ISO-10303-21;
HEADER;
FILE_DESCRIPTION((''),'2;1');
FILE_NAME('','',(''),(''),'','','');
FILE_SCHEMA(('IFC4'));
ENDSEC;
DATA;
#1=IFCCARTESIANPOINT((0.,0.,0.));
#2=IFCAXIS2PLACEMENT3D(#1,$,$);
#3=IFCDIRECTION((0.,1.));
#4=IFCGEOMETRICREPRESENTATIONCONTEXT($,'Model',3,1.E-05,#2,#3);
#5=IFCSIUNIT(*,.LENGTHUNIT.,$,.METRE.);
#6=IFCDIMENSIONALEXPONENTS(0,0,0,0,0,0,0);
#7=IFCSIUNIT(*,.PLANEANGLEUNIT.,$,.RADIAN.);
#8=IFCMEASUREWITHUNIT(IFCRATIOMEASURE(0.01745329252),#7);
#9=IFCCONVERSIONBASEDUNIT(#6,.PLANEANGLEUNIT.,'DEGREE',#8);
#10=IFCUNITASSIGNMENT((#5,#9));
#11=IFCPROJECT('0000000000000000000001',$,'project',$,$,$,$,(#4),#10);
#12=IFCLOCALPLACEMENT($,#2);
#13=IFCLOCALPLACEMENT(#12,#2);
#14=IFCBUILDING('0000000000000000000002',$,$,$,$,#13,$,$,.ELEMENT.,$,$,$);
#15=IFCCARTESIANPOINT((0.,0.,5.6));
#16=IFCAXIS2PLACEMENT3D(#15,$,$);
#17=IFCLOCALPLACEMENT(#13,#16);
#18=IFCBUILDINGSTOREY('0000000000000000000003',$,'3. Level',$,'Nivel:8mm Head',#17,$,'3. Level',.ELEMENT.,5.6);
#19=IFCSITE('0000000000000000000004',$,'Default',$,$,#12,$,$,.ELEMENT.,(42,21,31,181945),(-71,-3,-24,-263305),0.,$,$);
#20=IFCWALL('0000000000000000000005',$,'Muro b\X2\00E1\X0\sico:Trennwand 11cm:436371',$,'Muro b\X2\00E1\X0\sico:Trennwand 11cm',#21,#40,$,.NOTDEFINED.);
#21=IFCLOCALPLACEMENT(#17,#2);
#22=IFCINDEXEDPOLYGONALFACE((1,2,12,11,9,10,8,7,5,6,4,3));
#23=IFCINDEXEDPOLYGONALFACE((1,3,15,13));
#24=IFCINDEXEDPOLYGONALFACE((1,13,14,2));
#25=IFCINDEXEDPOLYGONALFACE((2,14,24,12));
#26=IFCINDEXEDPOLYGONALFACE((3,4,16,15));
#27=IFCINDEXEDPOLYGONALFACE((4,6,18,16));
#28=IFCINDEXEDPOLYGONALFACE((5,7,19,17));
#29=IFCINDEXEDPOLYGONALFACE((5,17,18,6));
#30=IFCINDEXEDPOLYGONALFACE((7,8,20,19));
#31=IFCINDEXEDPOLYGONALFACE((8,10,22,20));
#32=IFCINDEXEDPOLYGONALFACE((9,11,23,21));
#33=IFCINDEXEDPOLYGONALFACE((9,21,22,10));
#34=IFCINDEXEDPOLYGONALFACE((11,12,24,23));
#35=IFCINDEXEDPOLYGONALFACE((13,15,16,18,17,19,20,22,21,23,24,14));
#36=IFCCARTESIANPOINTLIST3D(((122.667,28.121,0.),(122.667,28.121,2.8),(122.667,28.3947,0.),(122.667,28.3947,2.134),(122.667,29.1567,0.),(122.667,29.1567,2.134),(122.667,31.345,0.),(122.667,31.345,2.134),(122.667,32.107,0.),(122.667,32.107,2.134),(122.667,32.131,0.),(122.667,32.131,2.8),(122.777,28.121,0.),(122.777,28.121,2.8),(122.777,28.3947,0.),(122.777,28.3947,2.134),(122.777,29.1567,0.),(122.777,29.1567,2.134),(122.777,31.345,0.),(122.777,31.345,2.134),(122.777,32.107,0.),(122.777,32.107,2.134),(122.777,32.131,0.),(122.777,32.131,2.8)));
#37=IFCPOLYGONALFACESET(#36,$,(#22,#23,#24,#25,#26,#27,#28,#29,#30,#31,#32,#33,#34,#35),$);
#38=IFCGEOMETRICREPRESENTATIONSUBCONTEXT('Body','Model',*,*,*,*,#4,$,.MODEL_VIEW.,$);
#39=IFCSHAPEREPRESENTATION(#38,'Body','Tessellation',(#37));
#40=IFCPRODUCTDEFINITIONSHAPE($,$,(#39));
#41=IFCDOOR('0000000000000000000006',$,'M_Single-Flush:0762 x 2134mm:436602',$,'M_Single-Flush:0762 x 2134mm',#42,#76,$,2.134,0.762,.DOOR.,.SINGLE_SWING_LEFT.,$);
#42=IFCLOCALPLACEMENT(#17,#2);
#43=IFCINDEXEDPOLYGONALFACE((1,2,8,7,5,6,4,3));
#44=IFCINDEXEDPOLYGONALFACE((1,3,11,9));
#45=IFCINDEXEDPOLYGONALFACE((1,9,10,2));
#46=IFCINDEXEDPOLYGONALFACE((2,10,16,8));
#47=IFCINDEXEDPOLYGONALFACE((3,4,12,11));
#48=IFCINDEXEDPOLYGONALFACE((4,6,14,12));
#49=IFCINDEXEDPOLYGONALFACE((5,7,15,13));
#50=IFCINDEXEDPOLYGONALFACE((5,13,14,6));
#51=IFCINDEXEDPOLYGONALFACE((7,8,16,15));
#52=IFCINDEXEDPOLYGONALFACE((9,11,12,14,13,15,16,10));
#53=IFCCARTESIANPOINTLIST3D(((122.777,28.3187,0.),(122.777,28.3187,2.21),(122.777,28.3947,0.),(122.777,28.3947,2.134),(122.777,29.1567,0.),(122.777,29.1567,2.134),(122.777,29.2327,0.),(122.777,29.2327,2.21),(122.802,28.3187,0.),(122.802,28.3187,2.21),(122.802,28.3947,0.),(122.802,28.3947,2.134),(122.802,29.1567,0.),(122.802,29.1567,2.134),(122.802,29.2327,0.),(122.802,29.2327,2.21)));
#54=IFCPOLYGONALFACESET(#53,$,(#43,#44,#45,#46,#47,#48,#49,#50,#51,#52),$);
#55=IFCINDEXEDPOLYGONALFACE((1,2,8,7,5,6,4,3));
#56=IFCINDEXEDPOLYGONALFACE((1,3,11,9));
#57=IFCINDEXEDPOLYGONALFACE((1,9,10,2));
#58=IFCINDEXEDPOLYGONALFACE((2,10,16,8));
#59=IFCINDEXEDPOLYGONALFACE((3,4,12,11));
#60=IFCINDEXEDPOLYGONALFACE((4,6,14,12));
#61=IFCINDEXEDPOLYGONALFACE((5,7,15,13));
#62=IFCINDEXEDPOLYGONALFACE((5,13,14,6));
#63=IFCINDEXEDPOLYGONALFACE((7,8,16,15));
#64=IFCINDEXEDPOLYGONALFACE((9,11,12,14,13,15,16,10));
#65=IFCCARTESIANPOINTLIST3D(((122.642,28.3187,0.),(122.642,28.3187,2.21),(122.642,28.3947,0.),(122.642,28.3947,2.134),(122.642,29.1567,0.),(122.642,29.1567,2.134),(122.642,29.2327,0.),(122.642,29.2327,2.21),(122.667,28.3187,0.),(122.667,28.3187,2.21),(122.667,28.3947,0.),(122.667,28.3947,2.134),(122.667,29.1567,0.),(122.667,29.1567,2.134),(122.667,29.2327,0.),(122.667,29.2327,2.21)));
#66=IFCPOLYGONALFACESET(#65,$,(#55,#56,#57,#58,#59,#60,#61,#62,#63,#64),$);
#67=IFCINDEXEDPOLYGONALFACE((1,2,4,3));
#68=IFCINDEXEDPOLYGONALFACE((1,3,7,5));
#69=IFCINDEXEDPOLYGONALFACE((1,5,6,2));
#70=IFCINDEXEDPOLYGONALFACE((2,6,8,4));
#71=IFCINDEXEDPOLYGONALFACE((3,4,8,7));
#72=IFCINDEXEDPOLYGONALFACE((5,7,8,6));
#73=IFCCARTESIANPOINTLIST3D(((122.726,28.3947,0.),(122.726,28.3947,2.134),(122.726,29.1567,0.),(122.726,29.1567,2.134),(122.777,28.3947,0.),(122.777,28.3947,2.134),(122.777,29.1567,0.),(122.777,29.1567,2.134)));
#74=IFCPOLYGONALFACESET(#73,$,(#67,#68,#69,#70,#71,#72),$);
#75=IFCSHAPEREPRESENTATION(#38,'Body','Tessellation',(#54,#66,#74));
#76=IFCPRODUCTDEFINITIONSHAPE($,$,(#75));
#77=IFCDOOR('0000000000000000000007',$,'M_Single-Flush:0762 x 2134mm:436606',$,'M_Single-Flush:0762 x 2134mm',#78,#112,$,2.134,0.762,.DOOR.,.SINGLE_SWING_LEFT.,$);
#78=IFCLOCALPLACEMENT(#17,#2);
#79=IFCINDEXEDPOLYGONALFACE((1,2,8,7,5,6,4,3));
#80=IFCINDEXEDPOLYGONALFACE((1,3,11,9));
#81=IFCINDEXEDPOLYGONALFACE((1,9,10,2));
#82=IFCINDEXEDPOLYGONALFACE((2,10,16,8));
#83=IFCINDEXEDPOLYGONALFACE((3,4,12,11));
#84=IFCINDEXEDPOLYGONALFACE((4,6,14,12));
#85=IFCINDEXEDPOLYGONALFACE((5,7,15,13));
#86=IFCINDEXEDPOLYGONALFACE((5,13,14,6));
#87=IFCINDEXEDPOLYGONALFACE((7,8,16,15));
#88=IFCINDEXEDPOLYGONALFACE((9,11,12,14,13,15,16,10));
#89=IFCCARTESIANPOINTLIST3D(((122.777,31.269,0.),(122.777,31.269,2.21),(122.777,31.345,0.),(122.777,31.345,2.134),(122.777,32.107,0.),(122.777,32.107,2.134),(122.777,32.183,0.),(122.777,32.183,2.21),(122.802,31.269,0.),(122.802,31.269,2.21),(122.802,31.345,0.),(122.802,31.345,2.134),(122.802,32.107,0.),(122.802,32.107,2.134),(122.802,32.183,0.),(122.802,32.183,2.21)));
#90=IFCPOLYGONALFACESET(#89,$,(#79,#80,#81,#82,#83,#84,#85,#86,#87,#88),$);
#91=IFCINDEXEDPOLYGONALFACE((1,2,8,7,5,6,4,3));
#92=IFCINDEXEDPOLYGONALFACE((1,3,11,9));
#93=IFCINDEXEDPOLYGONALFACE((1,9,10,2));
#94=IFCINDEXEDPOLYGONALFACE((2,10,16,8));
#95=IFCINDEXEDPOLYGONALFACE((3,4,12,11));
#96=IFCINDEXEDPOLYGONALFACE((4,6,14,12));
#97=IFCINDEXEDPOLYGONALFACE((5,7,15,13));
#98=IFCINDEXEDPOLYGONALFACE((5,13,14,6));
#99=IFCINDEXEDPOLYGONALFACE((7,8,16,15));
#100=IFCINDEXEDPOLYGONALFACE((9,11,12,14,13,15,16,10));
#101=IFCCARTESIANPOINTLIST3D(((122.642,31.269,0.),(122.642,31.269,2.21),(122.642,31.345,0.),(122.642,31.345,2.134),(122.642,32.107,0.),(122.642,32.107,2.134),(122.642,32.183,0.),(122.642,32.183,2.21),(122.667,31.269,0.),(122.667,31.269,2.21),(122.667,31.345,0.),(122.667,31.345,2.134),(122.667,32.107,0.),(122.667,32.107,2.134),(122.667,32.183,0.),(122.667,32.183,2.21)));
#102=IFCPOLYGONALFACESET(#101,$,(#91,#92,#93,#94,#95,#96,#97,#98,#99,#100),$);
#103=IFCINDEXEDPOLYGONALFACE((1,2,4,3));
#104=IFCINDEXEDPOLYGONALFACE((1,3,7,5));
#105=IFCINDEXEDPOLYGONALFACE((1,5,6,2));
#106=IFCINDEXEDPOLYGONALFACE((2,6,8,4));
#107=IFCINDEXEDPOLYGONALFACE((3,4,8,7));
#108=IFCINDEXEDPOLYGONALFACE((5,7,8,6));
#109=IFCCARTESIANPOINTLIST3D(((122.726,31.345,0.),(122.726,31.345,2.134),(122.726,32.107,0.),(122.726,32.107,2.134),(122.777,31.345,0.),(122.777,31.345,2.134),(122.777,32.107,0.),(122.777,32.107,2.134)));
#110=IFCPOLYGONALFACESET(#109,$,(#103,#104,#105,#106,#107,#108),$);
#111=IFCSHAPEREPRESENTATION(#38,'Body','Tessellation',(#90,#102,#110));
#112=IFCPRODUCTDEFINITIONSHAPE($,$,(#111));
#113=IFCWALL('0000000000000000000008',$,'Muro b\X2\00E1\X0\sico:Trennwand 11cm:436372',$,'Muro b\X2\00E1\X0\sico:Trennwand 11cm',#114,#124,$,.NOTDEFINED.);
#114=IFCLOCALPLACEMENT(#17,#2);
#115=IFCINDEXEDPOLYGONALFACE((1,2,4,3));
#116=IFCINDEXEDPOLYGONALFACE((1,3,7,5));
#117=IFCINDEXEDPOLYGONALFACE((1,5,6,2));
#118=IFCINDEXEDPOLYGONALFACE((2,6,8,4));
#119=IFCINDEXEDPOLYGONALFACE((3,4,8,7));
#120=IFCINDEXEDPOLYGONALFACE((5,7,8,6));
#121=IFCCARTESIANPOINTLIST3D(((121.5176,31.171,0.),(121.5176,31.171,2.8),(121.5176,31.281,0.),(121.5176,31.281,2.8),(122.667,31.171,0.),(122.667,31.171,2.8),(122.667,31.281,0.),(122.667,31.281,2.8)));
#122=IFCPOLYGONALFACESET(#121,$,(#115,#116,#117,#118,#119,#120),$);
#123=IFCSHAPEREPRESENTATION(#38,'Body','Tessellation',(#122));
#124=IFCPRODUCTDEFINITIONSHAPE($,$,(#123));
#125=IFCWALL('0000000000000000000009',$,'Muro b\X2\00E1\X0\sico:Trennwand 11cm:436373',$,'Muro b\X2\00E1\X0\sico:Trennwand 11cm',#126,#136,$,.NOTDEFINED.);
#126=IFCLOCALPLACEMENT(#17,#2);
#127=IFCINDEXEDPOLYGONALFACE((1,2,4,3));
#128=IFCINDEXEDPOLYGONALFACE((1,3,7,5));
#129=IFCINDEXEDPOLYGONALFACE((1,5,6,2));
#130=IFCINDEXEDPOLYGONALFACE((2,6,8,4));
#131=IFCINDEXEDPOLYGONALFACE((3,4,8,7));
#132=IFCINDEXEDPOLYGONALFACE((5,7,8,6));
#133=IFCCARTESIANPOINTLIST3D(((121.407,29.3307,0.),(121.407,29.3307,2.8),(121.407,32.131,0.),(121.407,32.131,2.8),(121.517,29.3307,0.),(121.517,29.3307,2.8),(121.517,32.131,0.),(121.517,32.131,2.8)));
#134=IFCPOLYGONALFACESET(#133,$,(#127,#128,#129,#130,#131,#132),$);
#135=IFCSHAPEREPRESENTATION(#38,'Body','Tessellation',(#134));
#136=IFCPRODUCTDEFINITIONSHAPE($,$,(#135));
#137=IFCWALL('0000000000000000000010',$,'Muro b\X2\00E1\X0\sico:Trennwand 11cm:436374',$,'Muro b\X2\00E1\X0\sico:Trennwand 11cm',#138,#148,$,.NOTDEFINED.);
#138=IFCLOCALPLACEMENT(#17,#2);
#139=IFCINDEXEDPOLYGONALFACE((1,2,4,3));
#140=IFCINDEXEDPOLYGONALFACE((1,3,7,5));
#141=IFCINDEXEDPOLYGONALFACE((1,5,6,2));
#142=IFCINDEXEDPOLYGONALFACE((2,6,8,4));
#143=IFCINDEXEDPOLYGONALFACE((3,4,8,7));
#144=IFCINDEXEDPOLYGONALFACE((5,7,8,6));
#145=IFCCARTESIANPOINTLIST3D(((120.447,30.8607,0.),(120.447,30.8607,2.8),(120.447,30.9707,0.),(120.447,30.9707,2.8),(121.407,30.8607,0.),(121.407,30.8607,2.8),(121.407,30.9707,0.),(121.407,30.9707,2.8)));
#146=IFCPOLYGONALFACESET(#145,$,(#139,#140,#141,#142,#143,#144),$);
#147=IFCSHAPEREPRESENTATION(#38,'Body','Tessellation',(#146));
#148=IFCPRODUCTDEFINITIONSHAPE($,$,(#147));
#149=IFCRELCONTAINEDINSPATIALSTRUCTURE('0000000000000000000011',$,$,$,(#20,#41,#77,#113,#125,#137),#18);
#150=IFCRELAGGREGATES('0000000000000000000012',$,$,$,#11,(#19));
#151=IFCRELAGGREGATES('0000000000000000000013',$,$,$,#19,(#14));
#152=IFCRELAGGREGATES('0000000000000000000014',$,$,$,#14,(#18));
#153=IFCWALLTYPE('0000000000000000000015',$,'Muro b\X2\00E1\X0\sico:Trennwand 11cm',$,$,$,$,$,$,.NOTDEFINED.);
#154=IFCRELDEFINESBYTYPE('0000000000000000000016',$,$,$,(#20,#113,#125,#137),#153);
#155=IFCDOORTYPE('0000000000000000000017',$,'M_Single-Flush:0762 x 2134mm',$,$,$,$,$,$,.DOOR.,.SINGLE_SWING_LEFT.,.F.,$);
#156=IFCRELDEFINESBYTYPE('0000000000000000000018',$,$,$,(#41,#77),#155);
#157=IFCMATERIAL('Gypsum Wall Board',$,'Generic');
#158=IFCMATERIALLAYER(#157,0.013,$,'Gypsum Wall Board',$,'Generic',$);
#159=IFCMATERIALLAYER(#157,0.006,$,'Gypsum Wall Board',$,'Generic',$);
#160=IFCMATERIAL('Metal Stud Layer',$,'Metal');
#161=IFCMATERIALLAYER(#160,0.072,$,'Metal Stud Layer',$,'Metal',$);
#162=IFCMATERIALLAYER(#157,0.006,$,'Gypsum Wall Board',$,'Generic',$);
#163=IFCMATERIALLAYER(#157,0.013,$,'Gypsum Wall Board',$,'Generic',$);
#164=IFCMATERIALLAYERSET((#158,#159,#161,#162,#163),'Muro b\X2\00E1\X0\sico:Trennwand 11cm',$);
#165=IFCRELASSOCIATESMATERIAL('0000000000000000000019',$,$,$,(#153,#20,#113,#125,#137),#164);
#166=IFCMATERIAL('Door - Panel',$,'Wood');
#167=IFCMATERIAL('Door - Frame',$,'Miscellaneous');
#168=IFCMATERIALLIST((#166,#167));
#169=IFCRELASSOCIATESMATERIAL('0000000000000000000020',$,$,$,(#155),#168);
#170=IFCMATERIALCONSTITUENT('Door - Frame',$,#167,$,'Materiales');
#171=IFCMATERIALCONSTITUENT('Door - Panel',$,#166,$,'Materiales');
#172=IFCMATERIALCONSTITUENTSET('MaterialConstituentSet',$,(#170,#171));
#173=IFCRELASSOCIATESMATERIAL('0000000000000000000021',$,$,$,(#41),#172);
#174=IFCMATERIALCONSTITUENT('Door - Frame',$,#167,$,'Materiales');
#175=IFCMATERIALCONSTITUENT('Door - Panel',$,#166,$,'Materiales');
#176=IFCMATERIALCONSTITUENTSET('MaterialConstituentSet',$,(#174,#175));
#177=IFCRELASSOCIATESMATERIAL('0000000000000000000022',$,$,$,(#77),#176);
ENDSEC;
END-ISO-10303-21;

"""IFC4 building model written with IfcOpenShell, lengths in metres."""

from ifc_helpers import new_model, entity, si_unit, converted_unit, direction, frame, frame_2d, origin, origin_2d_with_axis, place, context, subcontext, project, spatial, polyline, rectangle, outline, extrude, source, transform, mapped, material, material_list, layer, layer_set, layer_usage, constituent, constituent_set, type_object, type_shapes, element, fill, save


model = new_model("IFC4")

# Units and contexts
model_context = context("Model", 3, precision=1e-05, world=origin(), true_north=direction((0.0, 1.0)))
body_context = subcontext(model_context, "Body", "Model", "MODEL_VIEW")
ifc_project = project(units=[si_unit("LENGTHUNIT", "METRE"), converted_unit("PLANEANGLEUNIT", "DEGREE", entity("IfcRatioMeasure", 0.01745329252), si_unit("PLANEANGLEUNIT", "RADIAN"), dimensions=[0, 0, 0, 0, 0, 0, 0])], contexts=[model_context])

# Site, building, storey
site_placement = place(None, origin())
site = spatial("IfcSite", under=ifc_project, at=site_placement, Name="Default", CompositionType="ELEMENT", RefLatitude=(42, 21, 31, 181945), RefLongitude=(-71, -3, -24, -263305), RefElevation=0.0)
building_placement = place(site_placement, origin())
building = spatial("IfcBuilding", under=site, at=building_placement, CompositionType="ELEMENT")
storey_placement = place(building_placement, frame((0.0, 0.0, 5.6)))
storey = spatial("IfcBuildingStorey", under=building, at=storey_placement, Name="3. Level", ObjectType="Nivel:8mm Head", LongName="3. Level", CompositionType="ELEMENT", Elevation=5.6)

# Shared definitions
ifc_material_1 = material(Name="Gypsum Wall Board", Category="Generic")
ifc_layer_1 = layer(ifc_material_1, 0.013, Name="Gypsum Wall Board", Category="Generic")
ifc_layer_2 = layer(ifc_material_1, 0.006, Name="Gypsum Wall Board", Category="Generic")
ifc_material_2 = material(Name="Metal Stud Layer", Category="Metal")
ifc_layer_3 = layer(ifc_material_2, 0.072, Name="Metal Stud Layer", Category="Metal")
ifc_layer_4 = layer(ifc_material_1, 0.006, Name="Gypsum Wall Board", Category="Generic")
ifc_layer_5 = layer(ifc_material_1, 0.013, Name="Gypsum Wall Board", Category="Generic")
ifc_layer_set_1 = layer_set([ifc_layer_1, ifc_layer_2, ifc_layer_3, ifc_layer_4, ifc_layer_5], Name="Muro básico:Trennwand 11cm")
wall_type_1 = type_object("IfcWallType", Name="Muro básico:Trennwand 11cm", PredefinedType="NOTDEFINED", material=ifc_layer_set_1)
ifc_material_3 = material(Name="Door - Frame", Category="Miscellaneous")

# Shared definitions
ifc_material_4 = material(Name="Door - Panel", Category="Wood")
ifc_material_list_1 = material_list([ifc_material_4, ifc_material_3])
door_type_1 = type_object("IfcDoorType", Name="M_Single-Flush:0762 x 2134mm", OperationType="SINGLE_SWING_LEFT", ParameterTakesPrecedence=False, PredefinedType="DOOR", material=ifc_material_list_1)
shared_shape_1 = source(origin(), body_context, "Body", "SweptSolid", [
    extrude(outline(polyline([(-0.457, -1.124), (0.457, -1.124), (0.457, 1.086), (0.381, 1.086), (0.381, -1.048), (-0.381, -1.048), (-0.381, 1.086), (-0.457, 1.086), (-0.457, -1.124)])), frame((0.381, 0.135, 1.086), z_axis=(0.0, -1.0, 0.0), x_axis=(-1.0, 0.0, 0.0)), (0.0, 0.0, 1.0), 0.025),
    extrude(outline(polyline([(-1.124, -0.457), (1.086, -0.457), (1.086, -0.381), (-1.048, -0.381), (-1.048, 0.381), (1.086, 0.381), (1.086, 0.457), (-1.124, 0.457), (-1.124, -0.457)])), frame((0.381, 0.0, 1.086), z_axis=(0.0, -1.0, 0.0), x_axis=(0.0, 0.0, -1.0)), (0.0, 0.0, 1.0), 0.025),
    extrude(rectangle(XDim=0.762, YDim=0.051, at=origin_2d_with_axis()), frame((0.381, 0.0845, 0.0)), (0.0, 0.0, 1.0), 2.134),
])
type_shapes(door_type_1, [shared_shape_1])

# Wall, openings, doors
ifc_layer_usage_1 = layer_usage(ifc_layer_set_1, "AXIS2", "NEGATIVE", 0.055)
wall_1_placement = place(storey_placement, frame((122.722, 28.121, 0.0), z_axis=(0.0, 0.0, 1.0), x_axis=(0.0, 1.0, 0.0)))
wall_1 = element("IfcWall", 1, at=wall_1_placement, inside=storey, type_object=wall_type_1, material=ifc_layer_usage_1, Name="Muro básico:Trennwand 11cm:436371", ObjectType="Muro básico:Trennwand 11cm", PredefinedType="NOTDEFINED", context=body_context, shape_type="SweptSolid", body=[
    extrude(rectangle(XDim=4.01, YDim=0.11, at=frame_2d((2.005, 0.0), x_axis=(-1.0, 0.0))), origin(), (0.0, 0.0, 1.0), 2.8),
])
opening_1_placement = place(wall_1_placement, frame((1.0357, 0.055, 0.0)))
opening_1 = element("IfcOpeningElement", 2, at=opening_1_placement, cuts=wall_1, ObjectType="Opening", PredefinedType="OPENING", context=body_context, shape_type="SweptSolid", body=[
    extrude(rectangle(XDim=0.762, YDim=2.134, at=frame_2d((1.067, 0.381), x_axis=(0.0, -1.0))), frame((0.0, 0.0, 0.0), z_axis=(0.0, -1.0, 0.0), x_axis=(0.0, 0.0, 1.0)), (0.0, 0.0, 1.0), 0.11),
])
opening_2_placement = place(wall_1_placement, frame((3.986, 0.055, 0.0)))
opening_2 = element("IfcOpeningElement", 3, at=opening_2_placement, cuts=wall_1, ObjectType="Opening", PredefinedType="OPENING", context=body_context, shape_type="SweptSolid", body=[
    extrude(rectangle(XDim=0.762, YDim=2.134, at=frame_2d((1.067, 0.381), x_axis=(0.0, -1.0))), frame((0.0, 0.0, 0.0), z_axis=(0.0, -1.0, 0.0), x_axis=(0.0, 0.0, 1.0)), (0.0, 0.0, 1.0), 0.11),
])
ifc_constituent_1 = constituent(ifc_material_3, Name="Door - Frame", Category="Materiales")
ifc_constituent_2 = constituent(ifc_material_4, Name="Door - Panel", Category="Materiales")
ifc_constituent_set_1 = constituent_set(constituents=[ifc_constituent_1, ifc_constituent_2], Name="MaterialConstituentSet")
door_1_placement = place(opening_1_placement, frame((0.0, 0.0, 0.0), z_axis=(0.0, 0.0, 1.0), x_axis=(-1.0, 0.0, 0.0)))
door_1 = element("IfcDoor", 4, at=door_1_placement, inside=storey, type_object=door_type_1, material=ifc_constituent_set_1, Name="M_Single-Flush:0762 x 2134mm:436602", ObjectType="M_Single-Flush:0762 x 2134mm", OperationType="SINGLE_SWING_LEFT", OverallHeight=2.134, OverallWidth=0.762, PredefinedType="DOOR", context=body_context, shape_type="MappedRepresentation", body=[
    mapped(shared_shape_1, transform((0.0, 0.0, 0.0), scale=1.0)),
])
fill(opening_1, door_1)
ifc_constituent_3 = constituent(ifc_material_3, Name="Door - Frame", Category="Materiales")
ifc_constituent_4 = constituent(ifc_material_4, Name="Door - Panel", Category="Materiales")
ifc_constituent_set_2 = constituent_set(constituents=[ifc_constituent_3, ifc_constituent_4], Name="MaterialConstituentSet")
door_2_placement = place(opening_2_placement, frame((0.0, 0.0, 0.0), z_axis=(0.0, 0.0, 1.0), x_axis=(-1.0, 0.0, 0.0)))
door_2 = element("IfcDoor", 5, at=door_2_placement, inside=storey, type_object=door_type_1, material=ifc_constituent_set_2, Name="M_Single-Flush:0762 x 2134mm:436606", ObjectType="M_Single-Flush:0762 x 2134mm", OperationType="SINGLE_SWING_LEFT", OverallHeight=2.134, OverallWidth=0.762, PredefinedType="DOOR", context=body_context, shape_type="MappedRepresentation", body=[
    mapped(shared_shape_1, transform((0.0, 0.0, 0.0), scale=1.0)),
])
fill(opening_2, door_2)

# Walls
ifc_layer_usage_2 = layer_usage(ifc_layer_set_1, "AXIS2", "NEGATIVE", 0.055)
wall_2_placement = place(storey_placement, frame((122.667, 31.226, 0.0), z_axis=(0.0, 0.0, 1.0), x_axis=(-1.0, 0.0, 0.0)))
element("IfcWall", 6, at=wall_2_placement, inside=storey, type_object=wall_type_1, material=ifc_layer_usage_2, Name="Muro básico:Trennwand 11cm:436372", ObjectType="Muro básico:Trennwand 11cm", PredefinedType="NOTDEFINED", context=body_context, shape_type="SweptSolid", body=[
    extrude(rectangle(XDim=1.1494, YDim=0.11, at=frame_2d((0.5747, 0.0), x_axis=(-1.0, 0.0))), origin(), (0.0, 0.0, 1.0), 2.8),
])
ifc_layer_usage_3 = layer_usage(ifc_layer_set_1, "AXIS2", "NEGATIVE", 0.055)
wall_3_placement = place(storey_placement, frame((121.462, 32.131, 0.0), z_axis=(0.0, 0.0, 1.0), x_axis=(0.0, -1.0, 0.0)))
element("IfcWall", 7, at=wall_3_placement, inside=storey, type_object=wall_type_1, material=ifc_layer_usage_3, Name="Muro básico:Trennwand 11cm:436373", ObjectType="Muro básico:Trennwand 11cm", PredefinedType="NOTDEFINED", context=body_context, shape_type="SweptSolid", body=[
    extrude(rectangle(XDim=2.8003, YDim=0.11, at=frame_2d((1.4002, 0.0), x_axis=(-1.0, 0.0))), origin(), (0.0, 0.0, 1.0), 2.8),
])
ifc_layer_usage_4 = layer_usage(ifc_layer_set_1, "AXIS2", "NEGATIVE", 0.055)
wall_4_placement = place(storey_placement, frame((121.407, 30.9157, 0.0), z_axis=(0.0, 0.0, 1.0), x_axis=(-1.0, 0.0, 0.0)))
element("IfcWall", 8, at=wall_4_placement, inside=storey, type_object=wall_type_1, material=ifc_layer_usage_4, Name="Muro básico:Trennwand 11cm:436374", ObjectType="Muro básico:Trennwand 11cm", PredefinedType="NOTDEFINED", context=body_context, shape_type="SweptSolid", body=[
    extrude(rectangle(XDim=0.96, YDim=0.11, at=frame_2d((0.48, 0.0), x_axis=(-1.0, 0.0))), origin(), (0.0, 0.0, 1.0), 2.8),
])

save(model, "model.ifc")
